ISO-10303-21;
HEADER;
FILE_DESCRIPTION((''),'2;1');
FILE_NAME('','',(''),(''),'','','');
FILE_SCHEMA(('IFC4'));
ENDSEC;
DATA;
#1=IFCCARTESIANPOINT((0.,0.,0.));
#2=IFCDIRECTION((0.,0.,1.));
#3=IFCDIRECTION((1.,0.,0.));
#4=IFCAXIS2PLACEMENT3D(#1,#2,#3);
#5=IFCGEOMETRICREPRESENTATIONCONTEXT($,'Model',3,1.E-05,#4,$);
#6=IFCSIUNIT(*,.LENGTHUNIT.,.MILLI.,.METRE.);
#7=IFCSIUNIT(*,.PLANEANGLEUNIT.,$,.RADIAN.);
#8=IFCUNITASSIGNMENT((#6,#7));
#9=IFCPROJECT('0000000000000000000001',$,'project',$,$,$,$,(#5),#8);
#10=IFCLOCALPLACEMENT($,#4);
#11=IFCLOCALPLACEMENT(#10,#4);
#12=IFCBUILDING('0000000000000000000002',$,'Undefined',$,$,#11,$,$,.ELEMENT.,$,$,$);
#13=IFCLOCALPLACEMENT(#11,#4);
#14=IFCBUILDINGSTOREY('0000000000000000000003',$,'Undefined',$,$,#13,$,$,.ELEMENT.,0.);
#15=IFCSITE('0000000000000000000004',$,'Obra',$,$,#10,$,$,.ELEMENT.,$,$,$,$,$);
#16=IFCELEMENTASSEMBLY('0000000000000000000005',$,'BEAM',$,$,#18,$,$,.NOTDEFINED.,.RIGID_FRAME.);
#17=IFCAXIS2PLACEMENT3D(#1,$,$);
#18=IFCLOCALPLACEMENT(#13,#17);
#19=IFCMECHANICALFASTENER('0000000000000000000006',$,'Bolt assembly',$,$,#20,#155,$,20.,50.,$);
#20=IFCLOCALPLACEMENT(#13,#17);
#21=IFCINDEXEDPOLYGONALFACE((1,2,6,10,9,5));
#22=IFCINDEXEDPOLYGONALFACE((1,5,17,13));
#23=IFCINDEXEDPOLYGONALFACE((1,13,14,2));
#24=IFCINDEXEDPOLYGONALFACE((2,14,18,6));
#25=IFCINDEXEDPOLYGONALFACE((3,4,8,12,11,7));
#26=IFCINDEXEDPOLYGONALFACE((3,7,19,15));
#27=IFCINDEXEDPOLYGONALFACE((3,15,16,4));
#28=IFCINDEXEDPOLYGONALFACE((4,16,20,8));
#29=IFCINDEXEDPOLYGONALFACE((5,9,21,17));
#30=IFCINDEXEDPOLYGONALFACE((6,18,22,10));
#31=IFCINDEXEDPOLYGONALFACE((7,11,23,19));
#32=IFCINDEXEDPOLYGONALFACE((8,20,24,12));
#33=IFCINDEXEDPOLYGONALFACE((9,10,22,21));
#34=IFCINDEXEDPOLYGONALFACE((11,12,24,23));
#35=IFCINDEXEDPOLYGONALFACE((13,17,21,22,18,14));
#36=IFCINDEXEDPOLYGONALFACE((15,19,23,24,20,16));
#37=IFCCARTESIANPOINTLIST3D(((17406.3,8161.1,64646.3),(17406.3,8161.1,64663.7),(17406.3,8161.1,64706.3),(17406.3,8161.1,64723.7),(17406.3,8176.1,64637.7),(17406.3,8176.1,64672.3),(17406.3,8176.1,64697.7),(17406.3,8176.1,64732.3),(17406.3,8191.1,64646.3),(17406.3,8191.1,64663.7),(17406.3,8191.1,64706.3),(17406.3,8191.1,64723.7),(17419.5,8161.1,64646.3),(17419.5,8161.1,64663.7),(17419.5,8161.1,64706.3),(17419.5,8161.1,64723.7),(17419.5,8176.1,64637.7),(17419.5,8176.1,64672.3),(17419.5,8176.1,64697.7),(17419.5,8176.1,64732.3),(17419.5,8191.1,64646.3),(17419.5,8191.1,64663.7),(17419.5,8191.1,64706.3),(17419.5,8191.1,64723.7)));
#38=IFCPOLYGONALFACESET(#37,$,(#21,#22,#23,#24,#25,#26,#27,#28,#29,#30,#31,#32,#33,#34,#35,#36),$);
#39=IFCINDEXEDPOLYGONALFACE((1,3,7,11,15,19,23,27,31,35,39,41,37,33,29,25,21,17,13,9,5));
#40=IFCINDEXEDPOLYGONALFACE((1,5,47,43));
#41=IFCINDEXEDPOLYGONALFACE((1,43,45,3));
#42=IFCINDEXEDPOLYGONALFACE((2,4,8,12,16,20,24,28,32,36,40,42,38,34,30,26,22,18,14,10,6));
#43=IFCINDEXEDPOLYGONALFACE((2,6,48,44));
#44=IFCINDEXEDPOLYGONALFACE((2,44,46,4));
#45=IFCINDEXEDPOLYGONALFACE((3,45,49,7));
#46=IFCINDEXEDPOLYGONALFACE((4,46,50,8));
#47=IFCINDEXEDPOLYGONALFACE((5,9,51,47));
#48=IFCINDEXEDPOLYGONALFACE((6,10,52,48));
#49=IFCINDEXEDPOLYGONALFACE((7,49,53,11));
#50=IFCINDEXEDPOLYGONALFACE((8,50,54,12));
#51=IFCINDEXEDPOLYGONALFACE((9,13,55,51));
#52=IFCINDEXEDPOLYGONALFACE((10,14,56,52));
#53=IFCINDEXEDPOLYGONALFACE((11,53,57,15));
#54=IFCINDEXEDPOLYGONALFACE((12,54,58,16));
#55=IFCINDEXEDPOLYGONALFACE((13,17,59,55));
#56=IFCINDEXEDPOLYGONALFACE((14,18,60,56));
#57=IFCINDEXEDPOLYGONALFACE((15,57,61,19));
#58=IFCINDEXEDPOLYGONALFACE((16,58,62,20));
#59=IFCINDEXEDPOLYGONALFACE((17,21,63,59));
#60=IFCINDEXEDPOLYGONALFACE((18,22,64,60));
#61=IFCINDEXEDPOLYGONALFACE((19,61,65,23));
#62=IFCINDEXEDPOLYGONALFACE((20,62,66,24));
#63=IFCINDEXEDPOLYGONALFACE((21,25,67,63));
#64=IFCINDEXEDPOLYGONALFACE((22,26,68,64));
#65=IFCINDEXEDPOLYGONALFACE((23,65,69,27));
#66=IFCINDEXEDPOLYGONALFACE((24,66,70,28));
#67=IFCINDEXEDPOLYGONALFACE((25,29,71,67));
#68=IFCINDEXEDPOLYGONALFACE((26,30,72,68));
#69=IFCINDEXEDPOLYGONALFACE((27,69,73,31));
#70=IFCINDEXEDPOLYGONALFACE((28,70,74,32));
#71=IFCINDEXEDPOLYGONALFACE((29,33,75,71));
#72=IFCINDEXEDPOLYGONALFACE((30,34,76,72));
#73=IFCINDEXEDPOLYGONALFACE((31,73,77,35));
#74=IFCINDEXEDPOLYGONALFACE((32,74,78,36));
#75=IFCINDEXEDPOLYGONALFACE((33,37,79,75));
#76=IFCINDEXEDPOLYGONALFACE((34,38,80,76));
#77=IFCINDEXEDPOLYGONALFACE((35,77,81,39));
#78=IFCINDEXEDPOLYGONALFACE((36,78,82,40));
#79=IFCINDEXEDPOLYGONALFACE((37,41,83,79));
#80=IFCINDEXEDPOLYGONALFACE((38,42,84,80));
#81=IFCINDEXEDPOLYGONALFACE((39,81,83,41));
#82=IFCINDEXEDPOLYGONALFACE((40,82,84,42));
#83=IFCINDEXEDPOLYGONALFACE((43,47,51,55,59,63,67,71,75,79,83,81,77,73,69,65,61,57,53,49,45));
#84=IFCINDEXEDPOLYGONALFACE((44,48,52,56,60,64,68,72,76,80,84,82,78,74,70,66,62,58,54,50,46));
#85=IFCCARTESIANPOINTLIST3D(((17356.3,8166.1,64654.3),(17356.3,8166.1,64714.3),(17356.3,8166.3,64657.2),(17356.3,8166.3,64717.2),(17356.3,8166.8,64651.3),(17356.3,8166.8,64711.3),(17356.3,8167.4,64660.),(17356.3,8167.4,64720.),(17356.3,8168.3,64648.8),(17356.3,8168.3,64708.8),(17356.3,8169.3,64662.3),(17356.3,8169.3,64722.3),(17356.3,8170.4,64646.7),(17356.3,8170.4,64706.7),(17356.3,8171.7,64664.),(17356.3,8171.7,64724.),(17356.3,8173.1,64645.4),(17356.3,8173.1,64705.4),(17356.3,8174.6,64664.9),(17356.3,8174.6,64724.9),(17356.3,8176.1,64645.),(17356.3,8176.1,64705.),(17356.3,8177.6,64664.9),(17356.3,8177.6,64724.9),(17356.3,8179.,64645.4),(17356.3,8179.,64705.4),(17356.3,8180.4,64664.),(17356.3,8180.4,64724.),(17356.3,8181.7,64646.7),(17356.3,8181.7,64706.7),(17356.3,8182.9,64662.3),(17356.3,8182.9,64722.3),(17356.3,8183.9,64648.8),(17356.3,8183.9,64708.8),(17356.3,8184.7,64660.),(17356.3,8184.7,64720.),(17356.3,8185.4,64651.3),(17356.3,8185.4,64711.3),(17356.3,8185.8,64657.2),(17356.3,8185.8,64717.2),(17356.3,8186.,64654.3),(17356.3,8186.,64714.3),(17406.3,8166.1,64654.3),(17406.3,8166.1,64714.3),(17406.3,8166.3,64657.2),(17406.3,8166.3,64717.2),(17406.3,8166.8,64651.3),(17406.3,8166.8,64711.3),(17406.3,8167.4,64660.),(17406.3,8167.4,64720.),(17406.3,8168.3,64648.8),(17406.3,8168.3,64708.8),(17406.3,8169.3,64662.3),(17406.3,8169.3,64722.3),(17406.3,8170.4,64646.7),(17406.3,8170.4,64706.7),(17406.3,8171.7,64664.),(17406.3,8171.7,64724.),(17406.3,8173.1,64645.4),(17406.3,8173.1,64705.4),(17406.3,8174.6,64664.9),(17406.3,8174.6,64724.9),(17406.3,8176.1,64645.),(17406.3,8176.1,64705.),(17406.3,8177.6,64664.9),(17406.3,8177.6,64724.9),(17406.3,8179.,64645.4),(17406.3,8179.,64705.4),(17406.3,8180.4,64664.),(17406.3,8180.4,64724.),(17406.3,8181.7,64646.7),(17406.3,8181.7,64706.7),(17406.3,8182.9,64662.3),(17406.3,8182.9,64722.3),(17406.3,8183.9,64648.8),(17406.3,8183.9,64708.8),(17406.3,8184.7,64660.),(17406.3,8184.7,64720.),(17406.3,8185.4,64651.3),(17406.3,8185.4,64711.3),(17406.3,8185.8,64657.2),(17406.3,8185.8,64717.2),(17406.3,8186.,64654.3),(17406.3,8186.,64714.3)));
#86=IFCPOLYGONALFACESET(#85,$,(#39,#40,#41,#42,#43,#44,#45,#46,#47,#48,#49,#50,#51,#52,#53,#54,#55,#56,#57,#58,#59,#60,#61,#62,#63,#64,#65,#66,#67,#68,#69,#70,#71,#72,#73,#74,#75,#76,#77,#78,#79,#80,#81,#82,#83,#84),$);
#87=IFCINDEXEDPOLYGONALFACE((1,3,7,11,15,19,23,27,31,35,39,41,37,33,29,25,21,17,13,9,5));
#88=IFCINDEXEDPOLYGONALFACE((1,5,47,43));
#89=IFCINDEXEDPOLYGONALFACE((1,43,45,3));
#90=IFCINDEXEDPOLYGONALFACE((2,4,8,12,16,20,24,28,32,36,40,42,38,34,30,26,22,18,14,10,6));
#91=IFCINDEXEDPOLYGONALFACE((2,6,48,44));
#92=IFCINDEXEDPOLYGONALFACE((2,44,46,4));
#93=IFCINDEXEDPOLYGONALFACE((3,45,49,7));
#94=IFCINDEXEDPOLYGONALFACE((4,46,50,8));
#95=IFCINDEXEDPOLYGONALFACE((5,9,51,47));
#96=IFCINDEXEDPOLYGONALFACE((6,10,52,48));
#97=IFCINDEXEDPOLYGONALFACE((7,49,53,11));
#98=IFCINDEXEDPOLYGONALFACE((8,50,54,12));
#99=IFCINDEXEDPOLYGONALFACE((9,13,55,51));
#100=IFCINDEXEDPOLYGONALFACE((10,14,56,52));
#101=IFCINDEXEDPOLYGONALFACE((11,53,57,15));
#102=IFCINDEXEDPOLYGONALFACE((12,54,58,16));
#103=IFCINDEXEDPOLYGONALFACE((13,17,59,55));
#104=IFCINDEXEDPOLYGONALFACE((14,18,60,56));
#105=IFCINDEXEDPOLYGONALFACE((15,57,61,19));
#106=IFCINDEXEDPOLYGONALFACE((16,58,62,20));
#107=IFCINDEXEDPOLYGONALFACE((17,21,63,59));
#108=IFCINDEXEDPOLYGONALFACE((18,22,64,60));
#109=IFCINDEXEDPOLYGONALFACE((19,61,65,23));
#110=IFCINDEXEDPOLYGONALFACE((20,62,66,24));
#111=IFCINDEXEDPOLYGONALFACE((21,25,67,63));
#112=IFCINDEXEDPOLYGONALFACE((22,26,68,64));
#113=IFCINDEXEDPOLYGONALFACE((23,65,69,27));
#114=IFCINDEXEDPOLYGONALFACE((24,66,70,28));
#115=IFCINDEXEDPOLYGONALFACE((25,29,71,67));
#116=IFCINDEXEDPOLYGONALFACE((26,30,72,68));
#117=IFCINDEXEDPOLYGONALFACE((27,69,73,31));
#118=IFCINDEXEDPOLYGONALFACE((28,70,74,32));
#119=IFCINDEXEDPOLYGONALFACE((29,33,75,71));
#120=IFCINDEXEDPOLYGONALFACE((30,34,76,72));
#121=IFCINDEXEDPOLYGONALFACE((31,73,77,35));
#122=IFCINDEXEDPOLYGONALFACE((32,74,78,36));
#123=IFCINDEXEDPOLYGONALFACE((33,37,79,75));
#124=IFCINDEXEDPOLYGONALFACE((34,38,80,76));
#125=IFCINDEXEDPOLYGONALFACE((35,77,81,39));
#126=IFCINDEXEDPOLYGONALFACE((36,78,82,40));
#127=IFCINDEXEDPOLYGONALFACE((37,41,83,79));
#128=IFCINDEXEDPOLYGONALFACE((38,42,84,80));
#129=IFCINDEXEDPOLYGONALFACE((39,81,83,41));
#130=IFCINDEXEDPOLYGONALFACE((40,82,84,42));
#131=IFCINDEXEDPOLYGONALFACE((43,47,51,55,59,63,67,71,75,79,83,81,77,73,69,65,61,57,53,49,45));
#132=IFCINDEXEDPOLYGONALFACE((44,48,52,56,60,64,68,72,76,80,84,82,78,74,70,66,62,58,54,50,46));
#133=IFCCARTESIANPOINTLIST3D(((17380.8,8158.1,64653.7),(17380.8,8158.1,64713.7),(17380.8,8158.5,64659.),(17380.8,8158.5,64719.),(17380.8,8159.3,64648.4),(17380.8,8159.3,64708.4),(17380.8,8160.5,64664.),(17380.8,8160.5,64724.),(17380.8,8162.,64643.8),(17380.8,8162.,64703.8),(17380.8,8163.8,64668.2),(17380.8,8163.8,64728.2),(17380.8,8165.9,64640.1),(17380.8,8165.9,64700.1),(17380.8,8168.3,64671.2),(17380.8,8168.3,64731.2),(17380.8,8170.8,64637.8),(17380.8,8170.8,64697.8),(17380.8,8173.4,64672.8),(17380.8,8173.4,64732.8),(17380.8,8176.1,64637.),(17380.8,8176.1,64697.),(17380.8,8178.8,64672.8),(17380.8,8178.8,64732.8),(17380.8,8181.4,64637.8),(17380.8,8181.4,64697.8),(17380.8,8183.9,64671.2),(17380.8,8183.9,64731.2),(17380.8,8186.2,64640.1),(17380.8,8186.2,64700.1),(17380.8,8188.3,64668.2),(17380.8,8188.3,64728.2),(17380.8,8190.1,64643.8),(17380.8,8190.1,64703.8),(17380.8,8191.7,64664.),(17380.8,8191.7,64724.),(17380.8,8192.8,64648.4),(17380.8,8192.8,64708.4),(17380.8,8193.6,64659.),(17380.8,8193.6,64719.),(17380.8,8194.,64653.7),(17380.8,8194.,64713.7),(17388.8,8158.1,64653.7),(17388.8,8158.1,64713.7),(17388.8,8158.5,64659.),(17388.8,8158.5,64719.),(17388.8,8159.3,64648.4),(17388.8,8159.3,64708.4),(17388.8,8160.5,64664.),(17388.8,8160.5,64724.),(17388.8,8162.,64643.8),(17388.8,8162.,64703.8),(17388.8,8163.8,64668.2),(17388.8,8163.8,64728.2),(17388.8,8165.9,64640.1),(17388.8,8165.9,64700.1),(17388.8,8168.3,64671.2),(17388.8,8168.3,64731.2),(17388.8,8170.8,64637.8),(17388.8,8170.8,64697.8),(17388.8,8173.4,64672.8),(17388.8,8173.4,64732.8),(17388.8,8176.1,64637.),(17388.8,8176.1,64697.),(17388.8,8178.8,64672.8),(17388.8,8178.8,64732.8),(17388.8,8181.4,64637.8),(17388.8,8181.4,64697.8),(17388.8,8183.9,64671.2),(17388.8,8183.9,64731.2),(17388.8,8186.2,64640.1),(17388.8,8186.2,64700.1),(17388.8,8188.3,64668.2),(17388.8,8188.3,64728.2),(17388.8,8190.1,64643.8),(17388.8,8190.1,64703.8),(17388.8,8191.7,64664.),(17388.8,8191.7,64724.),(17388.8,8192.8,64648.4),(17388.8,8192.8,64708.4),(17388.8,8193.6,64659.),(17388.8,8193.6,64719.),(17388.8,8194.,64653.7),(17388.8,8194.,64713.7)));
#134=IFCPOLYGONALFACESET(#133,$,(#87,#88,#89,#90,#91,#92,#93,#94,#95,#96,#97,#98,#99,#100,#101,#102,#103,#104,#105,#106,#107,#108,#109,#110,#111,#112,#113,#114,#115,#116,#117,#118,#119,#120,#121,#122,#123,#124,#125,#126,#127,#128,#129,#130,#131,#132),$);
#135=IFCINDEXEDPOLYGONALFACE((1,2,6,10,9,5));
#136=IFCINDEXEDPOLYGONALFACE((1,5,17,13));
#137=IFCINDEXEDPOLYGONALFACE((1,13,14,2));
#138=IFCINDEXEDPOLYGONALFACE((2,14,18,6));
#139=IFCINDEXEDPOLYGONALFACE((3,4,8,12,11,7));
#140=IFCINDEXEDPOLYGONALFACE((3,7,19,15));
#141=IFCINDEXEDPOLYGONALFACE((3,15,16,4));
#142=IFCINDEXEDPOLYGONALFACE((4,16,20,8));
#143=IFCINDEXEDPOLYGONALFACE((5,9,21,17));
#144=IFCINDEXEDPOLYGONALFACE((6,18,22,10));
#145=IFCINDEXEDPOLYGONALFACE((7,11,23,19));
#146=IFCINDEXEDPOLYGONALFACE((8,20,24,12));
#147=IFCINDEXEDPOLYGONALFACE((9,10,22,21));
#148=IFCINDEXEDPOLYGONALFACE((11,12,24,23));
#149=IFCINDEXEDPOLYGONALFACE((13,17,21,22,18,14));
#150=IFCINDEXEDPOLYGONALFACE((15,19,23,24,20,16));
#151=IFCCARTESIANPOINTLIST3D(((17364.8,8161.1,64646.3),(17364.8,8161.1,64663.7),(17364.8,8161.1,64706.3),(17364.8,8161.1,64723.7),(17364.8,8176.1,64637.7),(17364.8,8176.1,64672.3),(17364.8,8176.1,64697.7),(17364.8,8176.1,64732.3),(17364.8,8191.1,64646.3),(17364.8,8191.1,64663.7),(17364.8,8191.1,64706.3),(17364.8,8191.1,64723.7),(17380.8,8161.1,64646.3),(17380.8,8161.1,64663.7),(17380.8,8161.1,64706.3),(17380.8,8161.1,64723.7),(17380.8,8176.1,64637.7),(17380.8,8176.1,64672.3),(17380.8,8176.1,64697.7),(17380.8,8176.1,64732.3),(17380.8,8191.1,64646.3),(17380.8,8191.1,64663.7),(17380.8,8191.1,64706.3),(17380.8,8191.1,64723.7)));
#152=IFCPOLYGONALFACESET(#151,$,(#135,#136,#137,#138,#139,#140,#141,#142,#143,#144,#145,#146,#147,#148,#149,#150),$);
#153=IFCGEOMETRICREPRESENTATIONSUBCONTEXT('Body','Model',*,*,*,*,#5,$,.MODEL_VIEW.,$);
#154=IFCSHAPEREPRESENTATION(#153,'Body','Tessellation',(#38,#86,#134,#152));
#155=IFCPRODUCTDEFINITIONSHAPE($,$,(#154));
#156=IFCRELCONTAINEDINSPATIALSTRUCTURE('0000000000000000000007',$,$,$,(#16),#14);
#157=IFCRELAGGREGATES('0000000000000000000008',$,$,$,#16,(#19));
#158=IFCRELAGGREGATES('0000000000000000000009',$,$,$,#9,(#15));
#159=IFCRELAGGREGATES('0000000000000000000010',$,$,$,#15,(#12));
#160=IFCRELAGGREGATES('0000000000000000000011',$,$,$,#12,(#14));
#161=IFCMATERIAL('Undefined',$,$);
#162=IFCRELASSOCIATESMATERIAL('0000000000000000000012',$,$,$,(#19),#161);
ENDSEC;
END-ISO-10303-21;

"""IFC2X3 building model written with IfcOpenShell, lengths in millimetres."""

from ifc_helpers import new_model, si_unit, frame, origin_with_axes, origin_2d_with_axis, place, context, subcontext, project, spatial, polyline, circle, outline, extrude, source, transform, mapped, material, element, aggregate, save


model = new_model("IFC2X3")

# Units and contexts
model_context = context("Model", 3, precision=1e-05, world=origin_with_axes())
body_context = subcontext(model_context, "Body", "Model", "MODEL_VIEW")
ifc_project = project(units=[si_unit("LENGTHUNIT", "METRE", prefix="MILLI"), si_unit("PLANEANGLEUNIT", "RADIAN")], contexts=[model_context])

# Site, building, storey
site_placement = place(None, origin_with_axes())
site = spatial("IfcSite", under=ifc_project, at=site_placement, Name="Obra", CompositionType="ELEMENT")
building_placement = place(site_placement, origin_with_axes())
building = spatial("IfcBuilding", under=site, at=building_placement, Name="Undefined", CompositionType="ELEMENT")
storey_placement = place(building_placement, origin_with_axes())
storey = spatial("IfcBuildingStorey", under=building, at=storey_placement, Name="Undefined", CompositionType="ELEMENT", Elevation=0.0)

# Shared definitions
ifc_material = material(Name="Undefined")

# Element assembly
assembly_1_placement = place(storey_placement, origin_with_axes())
assembly_1 = element("IfcElementAssembly", 1, at=assembly_1_placement, inside=storey, Name="BEAM", AssemblyPlace="NOTDEFINED", PredefinedType="RIGID_FRAME")
shared_shape_1 = source(origin_with_axes(), body_context, "Body", "SweptSolid", [
    extrude(outline(polyline([(17.3, 0.0), (8.7, 15.0), (-8.7, 15.0), (-17.3, 0.0), (-8.7, -15.0), (8.7, -15.0), (17.3, 0.0)])), frame((0.0, -27.0, 0.0), z_axis=(0.0, 1.0, 0.0), x_axis=(1.0, 0.0, 0.0)), (0.0, 0.0, 1.0), 13.2),
    extrude(circle(Radius=10.0, at=origin_2d_with_axis()), frame((0.0, -13.8, 0.0), z_axis=(0.0, 1.0, 0.0), x_axis=(1.0, 0.0, 0.0)), (0.0, 0.0, 1.0), 50.0),
    extrude(circle(Radius=18.0, at=origin_2d_with_axis()), frame((0.0, 3.7, 0.0), z_axis=(0.0, 1.0, 0.0), x_axis=(1.0, 0.0, 0.0)), (0.0, 0.0, 1.0), 8.0),
    extrude(outline(polyline([(17.3, 0.0), (8.7, 15.0), (-8.7, 15.0), (-17.3, 0.0), (-8.7, -15.0), (8.7, -15.0), (17.3, 0.0)])), frame((0.0, 11.7, 0.0), z_axis=(0.0, 1.0, 0.0), x_axis=(1.0, 0.0, 0.0)), (0.0, 0.0, 1.0), 16.0),
])

# Mechanical fastener
mechanical_fastener_1_placement = place(assembly_1_placement, frame((17392.6, 8136.1, 64850.0), z_axis=(0.0, 1.0, 0.0), x_axis=(0.0, 0.0, -1.0)))
mechanical_fastener_1 = element("IfcMechanicalFastener", 2, at=mechanical_fastener_1_placement, material=ifc_material, Name="Bolt assembly", NominalDiameter=20.0, NominalLength=50.0, context=body_context, shape_type="MappedRepresentation", body=[
    mapped(shared_shape_1, transform((135.0, 0.0, 40.0))),
    mapped(shared_shape_1, transform((195.0, 0.0, 40.0))),
])
aggregate(assembly_1, [mechanical_fastener_1])

save(model, "model.ifc")
